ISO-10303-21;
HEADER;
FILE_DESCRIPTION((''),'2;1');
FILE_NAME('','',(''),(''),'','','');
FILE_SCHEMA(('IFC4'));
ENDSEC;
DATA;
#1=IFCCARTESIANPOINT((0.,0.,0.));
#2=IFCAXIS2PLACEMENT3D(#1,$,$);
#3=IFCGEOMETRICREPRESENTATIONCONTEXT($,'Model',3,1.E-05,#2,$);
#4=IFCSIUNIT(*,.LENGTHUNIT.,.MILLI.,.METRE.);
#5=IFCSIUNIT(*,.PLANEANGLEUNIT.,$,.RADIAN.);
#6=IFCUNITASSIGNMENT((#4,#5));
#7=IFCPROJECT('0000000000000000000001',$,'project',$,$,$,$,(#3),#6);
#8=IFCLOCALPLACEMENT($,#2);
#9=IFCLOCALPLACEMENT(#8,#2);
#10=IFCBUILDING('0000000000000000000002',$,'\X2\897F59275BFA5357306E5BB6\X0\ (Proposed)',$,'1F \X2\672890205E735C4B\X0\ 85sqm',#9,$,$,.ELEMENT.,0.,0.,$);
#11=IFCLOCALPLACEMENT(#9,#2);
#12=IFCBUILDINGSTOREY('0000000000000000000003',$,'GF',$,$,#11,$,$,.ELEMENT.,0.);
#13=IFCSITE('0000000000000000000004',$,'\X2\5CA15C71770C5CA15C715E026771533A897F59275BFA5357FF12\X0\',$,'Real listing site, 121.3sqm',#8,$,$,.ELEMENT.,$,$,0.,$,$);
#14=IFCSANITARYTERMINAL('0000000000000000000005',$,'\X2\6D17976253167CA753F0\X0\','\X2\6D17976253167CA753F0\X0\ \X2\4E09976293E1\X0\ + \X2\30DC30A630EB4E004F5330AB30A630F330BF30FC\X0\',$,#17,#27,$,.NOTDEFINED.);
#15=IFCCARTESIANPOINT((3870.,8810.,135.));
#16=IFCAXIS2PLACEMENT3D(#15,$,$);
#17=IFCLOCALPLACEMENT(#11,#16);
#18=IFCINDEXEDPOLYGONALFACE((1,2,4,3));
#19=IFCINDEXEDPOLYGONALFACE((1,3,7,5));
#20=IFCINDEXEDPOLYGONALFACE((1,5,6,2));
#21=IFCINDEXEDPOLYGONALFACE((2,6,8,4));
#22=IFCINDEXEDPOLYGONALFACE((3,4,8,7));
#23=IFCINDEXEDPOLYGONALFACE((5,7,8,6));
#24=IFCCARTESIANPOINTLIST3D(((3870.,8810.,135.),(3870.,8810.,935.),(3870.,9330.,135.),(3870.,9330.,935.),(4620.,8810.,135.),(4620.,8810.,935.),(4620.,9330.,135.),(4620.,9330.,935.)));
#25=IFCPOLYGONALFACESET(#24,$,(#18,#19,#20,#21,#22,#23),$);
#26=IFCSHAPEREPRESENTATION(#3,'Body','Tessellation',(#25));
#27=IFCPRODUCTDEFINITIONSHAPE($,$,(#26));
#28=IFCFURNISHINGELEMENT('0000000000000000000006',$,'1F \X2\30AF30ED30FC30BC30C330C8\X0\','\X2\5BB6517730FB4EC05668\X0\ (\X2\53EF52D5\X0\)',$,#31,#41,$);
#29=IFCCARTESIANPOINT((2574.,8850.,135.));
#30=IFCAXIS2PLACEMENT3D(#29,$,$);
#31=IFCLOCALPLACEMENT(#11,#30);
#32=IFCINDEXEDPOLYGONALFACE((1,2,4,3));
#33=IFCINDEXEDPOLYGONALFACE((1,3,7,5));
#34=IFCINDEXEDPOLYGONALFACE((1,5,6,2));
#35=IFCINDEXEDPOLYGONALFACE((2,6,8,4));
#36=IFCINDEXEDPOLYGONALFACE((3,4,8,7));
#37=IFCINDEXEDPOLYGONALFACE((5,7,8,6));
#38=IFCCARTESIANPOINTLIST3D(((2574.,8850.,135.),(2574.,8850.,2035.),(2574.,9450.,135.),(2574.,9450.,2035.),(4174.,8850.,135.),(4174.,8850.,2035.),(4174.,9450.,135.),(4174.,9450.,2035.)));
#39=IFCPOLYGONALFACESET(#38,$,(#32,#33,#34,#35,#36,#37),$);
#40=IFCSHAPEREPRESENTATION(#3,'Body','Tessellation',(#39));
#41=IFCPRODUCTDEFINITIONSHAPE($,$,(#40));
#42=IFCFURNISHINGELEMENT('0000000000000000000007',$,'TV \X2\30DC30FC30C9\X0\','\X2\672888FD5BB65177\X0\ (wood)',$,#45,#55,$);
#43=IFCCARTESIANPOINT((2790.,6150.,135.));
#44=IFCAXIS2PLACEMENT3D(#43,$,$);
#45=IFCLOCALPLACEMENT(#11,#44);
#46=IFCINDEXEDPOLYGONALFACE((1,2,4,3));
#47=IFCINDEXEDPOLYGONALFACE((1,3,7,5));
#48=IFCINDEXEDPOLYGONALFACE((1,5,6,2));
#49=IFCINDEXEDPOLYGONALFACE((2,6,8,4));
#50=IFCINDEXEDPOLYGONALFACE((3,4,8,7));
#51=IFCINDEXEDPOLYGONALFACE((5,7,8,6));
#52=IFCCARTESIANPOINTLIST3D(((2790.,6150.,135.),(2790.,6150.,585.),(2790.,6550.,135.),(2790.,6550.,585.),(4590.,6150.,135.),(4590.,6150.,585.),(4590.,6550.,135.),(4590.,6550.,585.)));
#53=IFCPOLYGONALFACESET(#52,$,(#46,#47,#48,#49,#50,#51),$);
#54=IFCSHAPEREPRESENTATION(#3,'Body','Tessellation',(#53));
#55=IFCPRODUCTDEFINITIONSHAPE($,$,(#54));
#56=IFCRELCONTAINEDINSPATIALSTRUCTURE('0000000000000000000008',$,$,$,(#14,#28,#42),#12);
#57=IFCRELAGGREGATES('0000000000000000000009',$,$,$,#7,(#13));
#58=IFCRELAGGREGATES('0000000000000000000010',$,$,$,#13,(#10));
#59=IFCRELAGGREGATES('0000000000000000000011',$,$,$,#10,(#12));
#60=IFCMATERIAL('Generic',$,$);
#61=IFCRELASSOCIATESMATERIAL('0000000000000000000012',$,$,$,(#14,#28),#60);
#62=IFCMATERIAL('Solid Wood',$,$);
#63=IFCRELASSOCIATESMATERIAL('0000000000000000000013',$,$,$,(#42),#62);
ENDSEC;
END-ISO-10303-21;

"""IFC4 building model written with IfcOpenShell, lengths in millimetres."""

from ifc_helpers import new_model, si_unit, frame, frame_2d, origin, place, context, project, spatial, rectangle, extrude, material, element, save


model = new_model("IFC4")

# Units and contexts
model_context = context("Model", 3, precision=1e-05, world=origin())
ifc_project = project(units=[si_unit("LENGTHUNIT", "METRE", prefix="MILLI"), si_unit("PLANEANGLEUNIT", "RADIAN")], contexts=[model_context])

# Site, building, storey
site_placement = place(None, origin())
site = spatial("IfcSite", under=ifc_project, at=site_placement, Name="岡山県岡山市東区西大寺南２", ObjectType="Real listing site, 121.3sqm", CompositionType="ELEMENT", RefElevation=0.0)
building_placement = place(site_placement, origin())
building = spatial("IfcBuilding", under=site, at=building_placement, Name="西大寺南の家 (Proposed)", ObjectType="1F 木造平屋 85sqm", CompositionType="ELEMENT", ElevationOfRefHeight=0.0, ElevationOfTerrain=0.0)
storey_placement = place(building_placement, origin())
storey = spatial("IfcBuildingStorey", under=building, at=storey_placement, Name="GF", CompositionType="ELEMENT", Elevation=0.0)

# Shared definitions
ifc_material_1 = material(Name="Solid Wood")

# Shared definitions
ifc_material_2 = material(Name="Generic")

# Sanitary terminal
sanitary_terminal_1_placement = place(storey_placement, frame((3870.0, 8810.0, 135.0)))
element("IfcSanitaryTerminal", 1, at=sanitary_terminal_1_placement, inside=storey, material=ifc_material_2, Name="洗面化粧台", Description="洗面化粧台 三面鏡 + ボウル一体カウンター", PredefinedType="NOTDEFINED", context=model_context, shape_type="SweptSolid", body=[
    extrude(rectangle(XDim=750.0, YDim=520.0, at=frame_2d((375.0, 260.0))), frame((3870.0, 8810.0, 135.0)), (0.0, 0.0, 1.0), 800.0),
])

# Furnishing elements
furnishing_1_placement = place(storey_placement, frame((2574.0, 8850.0, 135.0)))
element("IfcFurnishingElement", 2, at=furnishing_1_placement, inside=storey, material=ifc_material_2, Name="1F クローゼット", Description="家具・什器 (可動)", context=model_context, shape_type="SweptSolid", body=[
    extrude(rectangle(XDim=1600.0, YDim=600.0, at=frame_2d((800.0, 300.0))), frame((2574.0, 8850.0, 135.0)), (0.0, 0.0, 1.0), 1900.0),
])
furnishing_2_placement = place(storey_placement, frame((2790.0, 6150.0, 135.0)))
element("IfcFurnishingElement", 3, at=furnishing_2_placement, inside=storey, material=ifc_material_1, Name="TV ボード", Description="木製家具 (wood)", context=model_context, shape_type="SweptSolid", body=[
    extrude(rectangle(XDim=1800.0, YDim=400.0, at=frame_2d((900.0, 200.0))), frame((2790.0, 6150.0, 135.0)), (0.0, 0.0, 1.0), 450.0),
])

save(model, "model.ifc")
